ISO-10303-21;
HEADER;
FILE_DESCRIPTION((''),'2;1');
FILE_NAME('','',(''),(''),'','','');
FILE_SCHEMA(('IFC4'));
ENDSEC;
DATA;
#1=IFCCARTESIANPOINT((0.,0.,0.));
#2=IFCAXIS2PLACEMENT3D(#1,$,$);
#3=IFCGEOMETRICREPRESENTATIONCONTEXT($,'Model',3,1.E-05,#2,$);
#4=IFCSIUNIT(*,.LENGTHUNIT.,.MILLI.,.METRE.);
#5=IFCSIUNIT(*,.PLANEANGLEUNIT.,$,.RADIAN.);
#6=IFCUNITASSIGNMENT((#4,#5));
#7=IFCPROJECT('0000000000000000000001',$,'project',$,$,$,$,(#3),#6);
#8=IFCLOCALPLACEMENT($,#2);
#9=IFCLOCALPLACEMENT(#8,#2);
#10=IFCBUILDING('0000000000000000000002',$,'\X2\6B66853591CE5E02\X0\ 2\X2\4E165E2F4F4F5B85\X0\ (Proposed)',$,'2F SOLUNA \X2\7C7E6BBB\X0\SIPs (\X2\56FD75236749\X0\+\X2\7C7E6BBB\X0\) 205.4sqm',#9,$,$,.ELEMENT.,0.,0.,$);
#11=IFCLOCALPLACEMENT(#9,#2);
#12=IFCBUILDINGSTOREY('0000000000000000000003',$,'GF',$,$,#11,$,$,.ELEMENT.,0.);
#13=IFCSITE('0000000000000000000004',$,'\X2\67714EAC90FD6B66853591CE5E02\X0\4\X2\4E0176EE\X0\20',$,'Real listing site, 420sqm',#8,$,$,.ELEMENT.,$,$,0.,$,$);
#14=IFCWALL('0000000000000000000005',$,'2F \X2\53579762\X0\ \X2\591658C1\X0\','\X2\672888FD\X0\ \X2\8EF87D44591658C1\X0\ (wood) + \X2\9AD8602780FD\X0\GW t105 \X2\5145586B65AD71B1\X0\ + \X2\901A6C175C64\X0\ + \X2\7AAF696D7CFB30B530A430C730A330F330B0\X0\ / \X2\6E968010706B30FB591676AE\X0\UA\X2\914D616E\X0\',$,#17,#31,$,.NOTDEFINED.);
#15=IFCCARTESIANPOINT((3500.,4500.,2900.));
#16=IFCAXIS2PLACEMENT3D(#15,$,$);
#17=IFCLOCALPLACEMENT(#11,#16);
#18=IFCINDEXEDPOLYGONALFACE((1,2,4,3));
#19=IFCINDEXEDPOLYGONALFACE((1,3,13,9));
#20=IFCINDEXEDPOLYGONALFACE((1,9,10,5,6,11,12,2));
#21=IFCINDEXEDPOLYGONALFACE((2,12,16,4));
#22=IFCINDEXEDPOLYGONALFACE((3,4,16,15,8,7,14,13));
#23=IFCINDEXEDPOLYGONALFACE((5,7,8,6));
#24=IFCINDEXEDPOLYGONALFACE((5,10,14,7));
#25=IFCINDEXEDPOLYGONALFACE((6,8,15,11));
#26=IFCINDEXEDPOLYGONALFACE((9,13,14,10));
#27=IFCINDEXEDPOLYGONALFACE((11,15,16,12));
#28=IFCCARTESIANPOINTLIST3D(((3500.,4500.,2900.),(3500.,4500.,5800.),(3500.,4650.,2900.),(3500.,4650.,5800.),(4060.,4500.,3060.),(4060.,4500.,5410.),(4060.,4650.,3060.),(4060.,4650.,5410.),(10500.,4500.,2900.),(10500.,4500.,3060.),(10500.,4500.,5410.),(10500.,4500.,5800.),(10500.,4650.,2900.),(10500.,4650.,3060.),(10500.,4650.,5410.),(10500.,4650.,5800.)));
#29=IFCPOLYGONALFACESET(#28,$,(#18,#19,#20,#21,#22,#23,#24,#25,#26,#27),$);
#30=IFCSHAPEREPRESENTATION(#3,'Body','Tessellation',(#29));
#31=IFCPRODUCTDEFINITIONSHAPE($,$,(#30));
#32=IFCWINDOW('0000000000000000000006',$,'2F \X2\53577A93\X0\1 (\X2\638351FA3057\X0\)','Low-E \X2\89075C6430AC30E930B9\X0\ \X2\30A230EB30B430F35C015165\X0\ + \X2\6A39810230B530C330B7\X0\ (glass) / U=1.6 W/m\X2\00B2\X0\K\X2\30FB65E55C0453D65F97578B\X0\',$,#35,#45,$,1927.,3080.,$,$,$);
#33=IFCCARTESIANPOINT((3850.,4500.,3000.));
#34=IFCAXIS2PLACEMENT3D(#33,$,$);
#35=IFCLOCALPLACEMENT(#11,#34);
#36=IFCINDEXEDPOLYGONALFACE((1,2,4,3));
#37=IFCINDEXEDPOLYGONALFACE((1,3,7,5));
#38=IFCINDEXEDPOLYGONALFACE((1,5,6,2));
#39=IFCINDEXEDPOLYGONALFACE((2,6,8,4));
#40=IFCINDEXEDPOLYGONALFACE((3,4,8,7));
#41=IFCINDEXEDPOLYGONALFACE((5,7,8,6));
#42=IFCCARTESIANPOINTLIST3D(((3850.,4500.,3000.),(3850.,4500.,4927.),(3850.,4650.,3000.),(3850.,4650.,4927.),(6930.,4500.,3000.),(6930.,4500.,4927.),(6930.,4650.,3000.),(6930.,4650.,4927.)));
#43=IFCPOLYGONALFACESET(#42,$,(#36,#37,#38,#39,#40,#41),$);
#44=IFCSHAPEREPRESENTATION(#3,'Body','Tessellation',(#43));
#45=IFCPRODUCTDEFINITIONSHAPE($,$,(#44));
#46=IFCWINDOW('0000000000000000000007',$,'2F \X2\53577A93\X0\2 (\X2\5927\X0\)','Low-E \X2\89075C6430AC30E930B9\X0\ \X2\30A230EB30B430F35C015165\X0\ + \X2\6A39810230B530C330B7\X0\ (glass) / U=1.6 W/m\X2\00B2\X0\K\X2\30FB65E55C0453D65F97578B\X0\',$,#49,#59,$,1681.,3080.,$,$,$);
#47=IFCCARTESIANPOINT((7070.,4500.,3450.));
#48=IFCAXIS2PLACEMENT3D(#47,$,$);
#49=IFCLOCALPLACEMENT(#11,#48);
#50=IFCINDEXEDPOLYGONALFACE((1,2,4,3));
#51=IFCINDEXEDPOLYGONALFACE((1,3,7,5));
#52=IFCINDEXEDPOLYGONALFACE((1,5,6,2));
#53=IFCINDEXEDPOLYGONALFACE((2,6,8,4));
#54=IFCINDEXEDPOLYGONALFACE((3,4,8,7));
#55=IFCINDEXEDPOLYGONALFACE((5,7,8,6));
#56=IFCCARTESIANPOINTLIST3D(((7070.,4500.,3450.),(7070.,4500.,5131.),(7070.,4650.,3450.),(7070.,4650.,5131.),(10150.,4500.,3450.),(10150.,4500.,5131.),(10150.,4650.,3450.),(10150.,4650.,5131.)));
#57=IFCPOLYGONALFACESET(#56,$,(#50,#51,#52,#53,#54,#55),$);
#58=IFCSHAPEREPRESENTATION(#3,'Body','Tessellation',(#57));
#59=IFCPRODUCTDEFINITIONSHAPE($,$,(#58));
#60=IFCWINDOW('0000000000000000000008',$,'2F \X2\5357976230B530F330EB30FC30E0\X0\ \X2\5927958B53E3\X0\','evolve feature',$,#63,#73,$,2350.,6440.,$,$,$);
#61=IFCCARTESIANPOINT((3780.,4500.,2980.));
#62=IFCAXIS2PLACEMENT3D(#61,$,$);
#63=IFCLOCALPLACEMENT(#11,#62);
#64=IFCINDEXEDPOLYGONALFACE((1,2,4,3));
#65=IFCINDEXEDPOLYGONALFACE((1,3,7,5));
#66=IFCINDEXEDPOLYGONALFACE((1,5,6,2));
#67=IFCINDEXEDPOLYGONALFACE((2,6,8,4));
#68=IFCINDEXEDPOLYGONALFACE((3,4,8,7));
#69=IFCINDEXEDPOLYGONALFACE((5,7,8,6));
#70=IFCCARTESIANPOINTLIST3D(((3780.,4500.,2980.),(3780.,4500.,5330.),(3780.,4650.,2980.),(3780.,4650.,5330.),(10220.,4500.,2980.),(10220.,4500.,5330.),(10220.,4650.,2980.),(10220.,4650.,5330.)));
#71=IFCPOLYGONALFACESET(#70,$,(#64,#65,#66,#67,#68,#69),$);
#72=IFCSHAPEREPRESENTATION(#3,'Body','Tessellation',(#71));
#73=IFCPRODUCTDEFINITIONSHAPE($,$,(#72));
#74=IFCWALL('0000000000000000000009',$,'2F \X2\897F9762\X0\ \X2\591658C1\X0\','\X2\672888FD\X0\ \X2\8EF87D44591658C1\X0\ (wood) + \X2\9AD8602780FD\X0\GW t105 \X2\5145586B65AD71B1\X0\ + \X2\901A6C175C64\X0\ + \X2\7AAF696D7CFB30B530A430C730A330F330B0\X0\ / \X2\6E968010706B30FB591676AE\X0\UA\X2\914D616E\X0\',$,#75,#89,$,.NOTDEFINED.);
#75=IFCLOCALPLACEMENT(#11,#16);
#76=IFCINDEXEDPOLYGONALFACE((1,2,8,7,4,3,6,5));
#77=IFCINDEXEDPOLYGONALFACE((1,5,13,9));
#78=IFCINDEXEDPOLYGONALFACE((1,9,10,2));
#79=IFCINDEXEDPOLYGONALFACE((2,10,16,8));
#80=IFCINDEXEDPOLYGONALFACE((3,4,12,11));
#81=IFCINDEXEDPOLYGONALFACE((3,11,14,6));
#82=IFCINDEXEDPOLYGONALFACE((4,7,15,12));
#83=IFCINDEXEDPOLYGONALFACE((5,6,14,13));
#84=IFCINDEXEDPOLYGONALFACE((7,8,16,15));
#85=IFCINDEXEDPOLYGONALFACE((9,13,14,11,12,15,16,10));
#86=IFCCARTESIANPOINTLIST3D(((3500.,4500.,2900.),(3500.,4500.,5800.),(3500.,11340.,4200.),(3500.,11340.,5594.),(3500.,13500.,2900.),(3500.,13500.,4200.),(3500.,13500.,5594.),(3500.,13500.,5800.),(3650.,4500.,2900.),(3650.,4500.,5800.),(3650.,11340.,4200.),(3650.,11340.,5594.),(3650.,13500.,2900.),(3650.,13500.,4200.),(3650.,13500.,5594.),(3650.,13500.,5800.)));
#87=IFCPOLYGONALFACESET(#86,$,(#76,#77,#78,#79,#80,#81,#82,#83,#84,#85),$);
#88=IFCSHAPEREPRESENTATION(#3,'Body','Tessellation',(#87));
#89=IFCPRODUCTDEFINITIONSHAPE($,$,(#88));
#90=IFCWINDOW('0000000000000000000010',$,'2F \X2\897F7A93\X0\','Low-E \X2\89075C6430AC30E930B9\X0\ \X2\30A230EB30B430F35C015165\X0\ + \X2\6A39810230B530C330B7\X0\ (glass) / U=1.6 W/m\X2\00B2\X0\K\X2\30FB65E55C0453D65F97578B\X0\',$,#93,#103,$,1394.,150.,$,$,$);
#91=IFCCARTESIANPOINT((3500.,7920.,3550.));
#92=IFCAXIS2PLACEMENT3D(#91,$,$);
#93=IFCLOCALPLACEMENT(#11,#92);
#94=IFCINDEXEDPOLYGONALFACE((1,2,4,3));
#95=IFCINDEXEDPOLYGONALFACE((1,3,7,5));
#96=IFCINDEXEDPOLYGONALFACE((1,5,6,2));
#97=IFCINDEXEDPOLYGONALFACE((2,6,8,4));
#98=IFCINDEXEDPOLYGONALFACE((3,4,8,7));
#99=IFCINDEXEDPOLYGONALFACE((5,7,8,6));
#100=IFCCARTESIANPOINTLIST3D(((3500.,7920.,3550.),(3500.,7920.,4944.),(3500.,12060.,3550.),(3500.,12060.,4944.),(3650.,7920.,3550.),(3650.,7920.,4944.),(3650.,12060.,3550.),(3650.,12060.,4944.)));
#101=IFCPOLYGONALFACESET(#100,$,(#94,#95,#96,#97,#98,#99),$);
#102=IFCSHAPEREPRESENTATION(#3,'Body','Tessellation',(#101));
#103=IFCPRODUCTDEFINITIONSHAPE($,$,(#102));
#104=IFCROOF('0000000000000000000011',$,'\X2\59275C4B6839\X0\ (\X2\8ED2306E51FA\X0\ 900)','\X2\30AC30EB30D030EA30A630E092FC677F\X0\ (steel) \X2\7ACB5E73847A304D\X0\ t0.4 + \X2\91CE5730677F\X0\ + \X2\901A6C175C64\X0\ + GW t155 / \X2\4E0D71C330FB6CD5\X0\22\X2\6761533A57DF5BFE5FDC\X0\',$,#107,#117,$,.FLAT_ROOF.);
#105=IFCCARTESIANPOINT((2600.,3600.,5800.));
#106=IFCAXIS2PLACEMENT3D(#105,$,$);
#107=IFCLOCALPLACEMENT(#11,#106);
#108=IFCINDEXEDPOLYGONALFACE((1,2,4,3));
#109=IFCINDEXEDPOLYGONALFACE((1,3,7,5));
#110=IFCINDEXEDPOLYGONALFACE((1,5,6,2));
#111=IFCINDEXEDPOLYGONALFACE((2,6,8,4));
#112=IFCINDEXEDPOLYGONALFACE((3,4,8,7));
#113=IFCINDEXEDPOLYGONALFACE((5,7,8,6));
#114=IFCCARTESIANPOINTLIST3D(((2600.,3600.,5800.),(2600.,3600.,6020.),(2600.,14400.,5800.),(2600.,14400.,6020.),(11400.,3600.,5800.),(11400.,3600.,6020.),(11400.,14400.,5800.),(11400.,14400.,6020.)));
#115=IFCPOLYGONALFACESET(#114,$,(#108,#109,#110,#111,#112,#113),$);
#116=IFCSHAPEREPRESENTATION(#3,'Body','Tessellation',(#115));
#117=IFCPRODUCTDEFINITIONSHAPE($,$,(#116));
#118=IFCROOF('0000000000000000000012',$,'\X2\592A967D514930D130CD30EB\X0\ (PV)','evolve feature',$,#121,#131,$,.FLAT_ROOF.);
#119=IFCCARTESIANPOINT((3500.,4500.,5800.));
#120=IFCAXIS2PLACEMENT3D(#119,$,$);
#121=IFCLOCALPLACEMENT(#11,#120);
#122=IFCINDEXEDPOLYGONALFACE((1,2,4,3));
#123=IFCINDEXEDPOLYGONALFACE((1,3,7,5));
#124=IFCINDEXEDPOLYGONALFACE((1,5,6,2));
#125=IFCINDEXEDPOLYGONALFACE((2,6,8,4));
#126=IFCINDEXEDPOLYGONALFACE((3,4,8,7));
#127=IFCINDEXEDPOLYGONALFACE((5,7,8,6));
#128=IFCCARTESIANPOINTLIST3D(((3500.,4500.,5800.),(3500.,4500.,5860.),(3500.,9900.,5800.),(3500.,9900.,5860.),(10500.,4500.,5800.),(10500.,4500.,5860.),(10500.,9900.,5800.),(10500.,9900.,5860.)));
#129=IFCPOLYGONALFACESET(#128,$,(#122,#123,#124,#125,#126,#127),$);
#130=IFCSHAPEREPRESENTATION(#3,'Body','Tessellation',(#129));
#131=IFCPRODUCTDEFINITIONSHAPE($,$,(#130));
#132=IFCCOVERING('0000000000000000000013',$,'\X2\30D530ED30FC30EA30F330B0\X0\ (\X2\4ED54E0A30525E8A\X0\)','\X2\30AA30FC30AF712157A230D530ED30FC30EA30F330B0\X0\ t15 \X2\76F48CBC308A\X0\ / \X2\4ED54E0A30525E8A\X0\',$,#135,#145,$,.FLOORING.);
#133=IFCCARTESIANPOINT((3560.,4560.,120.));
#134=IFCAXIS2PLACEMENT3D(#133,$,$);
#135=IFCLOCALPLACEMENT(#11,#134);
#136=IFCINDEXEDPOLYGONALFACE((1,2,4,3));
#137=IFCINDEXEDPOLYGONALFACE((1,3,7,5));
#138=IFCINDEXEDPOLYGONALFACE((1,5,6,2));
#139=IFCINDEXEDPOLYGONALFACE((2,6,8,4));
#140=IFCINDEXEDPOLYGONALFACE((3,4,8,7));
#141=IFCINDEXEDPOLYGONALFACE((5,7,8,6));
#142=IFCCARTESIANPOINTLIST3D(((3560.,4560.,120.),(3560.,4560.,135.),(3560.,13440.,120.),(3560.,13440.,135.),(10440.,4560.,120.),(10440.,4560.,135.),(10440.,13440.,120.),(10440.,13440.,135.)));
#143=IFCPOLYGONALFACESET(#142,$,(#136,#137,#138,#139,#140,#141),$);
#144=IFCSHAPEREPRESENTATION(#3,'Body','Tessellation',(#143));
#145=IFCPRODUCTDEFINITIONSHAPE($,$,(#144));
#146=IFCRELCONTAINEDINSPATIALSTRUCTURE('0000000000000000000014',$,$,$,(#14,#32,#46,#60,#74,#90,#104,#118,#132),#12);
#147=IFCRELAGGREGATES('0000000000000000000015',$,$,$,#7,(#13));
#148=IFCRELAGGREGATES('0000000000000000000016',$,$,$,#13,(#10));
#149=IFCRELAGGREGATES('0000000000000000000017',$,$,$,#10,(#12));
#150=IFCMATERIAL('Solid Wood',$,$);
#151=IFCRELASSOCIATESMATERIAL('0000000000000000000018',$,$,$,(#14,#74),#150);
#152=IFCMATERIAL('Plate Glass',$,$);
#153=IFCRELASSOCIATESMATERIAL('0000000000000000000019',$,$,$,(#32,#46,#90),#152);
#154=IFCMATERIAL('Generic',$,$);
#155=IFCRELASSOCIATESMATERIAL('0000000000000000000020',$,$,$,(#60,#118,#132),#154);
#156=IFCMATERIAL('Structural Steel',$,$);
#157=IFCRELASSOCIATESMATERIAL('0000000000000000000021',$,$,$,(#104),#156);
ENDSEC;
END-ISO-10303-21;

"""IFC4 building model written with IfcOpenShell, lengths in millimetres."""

from ifc_helpers import new_model, si_unit, frame, frame_2d, origin, place, context, project, spatial, rectangle, extrude, material, element, fill, save


model = new_model("IFC4")

# Units and contexts
model_context = context("Model", 3, precision=1e-05, world=origin())
ifc_project = project(units=[si_unit("LENGTHUNIT", "METRE", prefix="MILLI"), si_unit("PLANEANGLEUNIT", "RADIAN")], contexts=[model_context])

# Site, building, storey
site_placement = place(None, origin())
site = spatial("IfcSite", under=ifc_project, at=site_placement, Name="東京都武蔵野市4丁目20", ObjectType="Real listing site, 420sqm", CompositionType="ELEMENT", RefElevation=0.0)
building_placement = place(site_placement, origin())
building = spatial("IfcBuilding", under=site, at=building_placement, Name="武蔵野市 2世帯住宅 (Proposed)", ObjectType="2F SOLUNA 籾殻SIPs (国産杉+籾殻) 205.4sqm", CompositionType="ELEMENT", ElevationOfRefHeight=0.0, ElevationOfTerrain=0.0)
storey_placement = place(building_placement, origin())
storey = spatial("IfcBuildingStorey", under=building, at=storey_placement, Name="GF", CompositionType="ELEMENT", Elevation=0.0)

# Shared definitions
ifc_material_1 = material(Name="Solid Wood")

# Shared definitions
ifc_material_2 = material(Name="Plate Glass")
ifc_material_3 = material(Name="Generic")

# Wall, openings, windows
wall_1_placement = place(storey_placement, frame((3500.0, 4500.0, 2900.0)))
wall_1 = element("IfcWall", 1, at=wall_1_placement, inside=storey, material=ifc_material_1, Name="2F 南面 外壁", Description="木製 軸組外壁 (wood) + 高性能GW t105 充填断熱 + 通気層 + 窯業系サイディング / 準耐火・外皮UA配慮", PredefinedType="NOTDEFINED", context=model_context, shape_type="SweptSolid", body=[
    extrude(rectangle(XDim=7000.0, YDim=150.0, at=frame_2d((3500.0, 75.0))), frame((3500.0, 4500.0, 2900.0)), (0.0, 0.0, 1.0), 2900.0),
])
opening_1_placement = place(storey_placement, frame((3850.0, 4500.0, 3000.0)))
opening_1 = element("IfcOpeningElement", 2, at=opening_1_placement, cuts=wall_1, PredefinedType="NOTDEFINED", context=model_context, shape_type="SweptSolid", body=[
    extrude(rectangle(XDim=3080.0, YDim=150.0, at=frame_2d((1540.0, 75.0))), frame((3850.0, 4500.0, 3000.0)), (0.0, 0.0, 1.0), 1927.0),
])
opening_2_placement = place(storey_placement, frame((7070.0, 4500.0, 3450.0)))
opening_2 = element("IfcOpeningElement", 3, at=opening_2_placement, cuts=wall_1, PredefinedType="NOTDEFINED", context=model_context, shape_type="SweptSolid", body=[
    extrude(rectangle(XDim=3080.0, YDim=150.0, at=frame_2d((1540.0, 75.0))), frame((7070.0, 4500.0, 3450.0)), (0.0, 0.0, 1.0), 1681.0),
])
opening_3_placement = place(storey_placement, frame((3780.0, 4500.0, 2980.0)))
opening_3 = element("IfcOpeningElement", 4, at=opening_3_placement, cuts=wall_1, PredefinedType="NOTDEFINED", context=model_context, shape_type="SweptSolid", body=[
    extrude(rectangle(XDim=6440.0, YDim=150.0, at=frame_2d((3220.0, 75.0))), frame((3780.0, 4500.0, 2980.0)), (0.0, 0.0, 1.0), 2350.0),
])
window_1_placement = place(storey_placement, frame((3850.0, 4500.0, 3000.0)))
window_1 = element("IfcWindow", 5, at=window_1_placement, inside=storey, material=ifc_material_2, Name="2F 南窓1 (掃出し)", Description="Low-E 複層ガラス アルゴン封入 + 樹脂サッシ (glass) / U=1.6 W/m²K・日射取得型", OverallHeight=1927.0, OverallWidth=3080.0, context=model_context, shape_type="SweptSolid", body=[
    extrude(rectangle(XDim=3080.0, YDim=150.0, at=frame_2d((1540.0, 75.0))), frame((3850.0, 4500.0, 3000.0)), (0.0, 0.0, 1.0), 1927.0),
])
fill(opening_1, window_1)
window_2_placement = place(storey_placement, frame((7070.0, 4500.0, 3450.0)))
window_2 = element("IfcWindow", 6, at=window_2_placement, inside=storey, material=ifc_material_2, Name="2F 南窓2 (大)", Description="Low-E 複層ガラス アルゴン封入 + 樹脂サッシ (glass) / U=1.6 W/m²K・日射取得型", OverallHeight=1681.0, OverallWidth=3080.0, context=model_context, shape_type="SweptSolid", body=[
    extrude(rectangle(XDim=3080.0, YDim=150.0, at=frame_2d((1540.0, 75.0))), frame((7070.0, 4500.0, 3450.0)), (0.0, 0.0, 1.0), 1681.0),
])
fill(opening_2, window_2)
window_3_placement = place(storey_placement, frame((3780.0, 4500.0, 2980.0)))
window_3 = element("IfcWindow", 7, at=window_3_placement, inside=storey, material=ifc_material_3, Name="2F 南面サンルーム 大開口", Description="evolve feature", OverallHeight=2350.0, OverallWidth=6440.0, context=model_context, shape_type="SweptSolid", body=[
    extrude(rectangle(XDim=6440.0, YDim=150.0, at=frame_2d((3220.0, 75.0))), frame((3780.0, 4500.0, 2980.0)), (0.0, 0.0, 1.0), 2350.0),
])
fill(opening_3, window_3)

# Wall, opening, window
wall_2_placement = place(storey_placement, frame((3500.0, 4500.0, 2900.0)))
wall_2 = element("IfcWall", 8, at=wall_2_placement, inside=storey, material=ifc_material_1, Name="2F 西面 外壁", Description="木製 軸組外壁 (wood) + 高性能GW t105 充填断熱 + 通気層 + 窯業系サイディング / 準耐火・外皮UA配慮", PredefinedType="NOTDEFINED", context=model_context, shape_type="SweptSolid", body=[
    extrude(rectangle(XDim=150.0, YDim=9000.0, at=frame_2d((75.0, 4500.0))), frame((3500.0, 4500.0, 2900.0)), (0.0, 0.0, 1.0), 2900.0),
])
opening_4_placement = place(storey_placement, frame((3500.0, 7920.0, 3550.0)))
opening_4 = element("IfcOpeningElement", 9, at=opening_4_placement, cuts=wall_2, PredefinedType="NOTDEFINED", context=model_context, shape_type="SweptSolid", body=[
    extrude(rectangle(XDim=150.0, YDim=4140.0, at=frame_2d((75.0, 2070.0))), frame((3500.0, 7920.0, 3550.0)), (0.0, 0.0, 1.0), 1394.0),
])
window_4_placement = place(storey_placement, frame((3500.0, 7920.0, 3550.0)))
window_4 = element("IfcWindow", 10, at=window_4_placement, inside=storey, material=ifc_material_2, Name="2F 西窓", Description="Low-E 複層ガラス アルゴン封入 + 樹脂サッシ (glass) / U=1.6 W/m²K・日射取得型", OverallHeight=1394.0, OverallWidth=150.0, context=model_context, shape_type="SweptSolid", body=[
    extrude(rectangle(XDim=150.0, YDim=4140.0, at=frame_2d((75.0, 2070.0))), frame((3500.0, 7920.0, 3550.0)), (0.0, 0.0, 1.0), 1394.0),
])
fill(opening_4, window_4)

# Roofs
ifc_material_4 = material(Name="Structural Steel")
roof_1_placement = place(storey_placement, frame((2600.0, 3600.0, 5800.0)))
element("IfcRoof", 11, at=roof_1_placement, inside=storey, material=ifc_material_4, Name="大屋根 (軒の出 900)", Description="ガルバリウム鋼板 (steel) 立平葺き t0.4 + 野地板 + 通気層 + GW t155 / 不燃・法22条区域対応", PredefinedType="FLAT_ROOF", context=model_context, shape_type="SweptSolid", body=[
    extrude(rectangle(XDim=8800.0, YDim=10800.0, at=frame_2d((4400.0, 5400.0))), frame((2600.0, 3600.0, 5800.0)), (0.0, 0.0, 1.0), 220.0),
])
roof_2_placement = place(storey_placement, frame((3500.0, 4500.0, 5800.0)))
element("IfcRoof", 12, at=roof_2_placement, inside=storey, material=ifc_material_3, Name="太陽光パネル (PV)", Description="evolve feature", PredefinedType="FLAT_ROOF", context=model_context, shape_type="SweptSolid", body=[
    extrude(rectangle(XDim=7000.0, YDim=5400.0, at=frame_2d((3500.0, 2700.0))), frame((3500.0, 4500.0, 5800.0)), (0.0, 0.0, 1.0), 60.0),
])

# Covering
covering_placement = place(storey_placement, frame((3560.0, 4560.0, 120.0)))
element("IfcCovering", 13, at=covering_placement, inside=storey, material=ifc_material_3, Name="フローリング (仕上げ床)", Description="オーク無垢フローリング t15 直貼り / 仕上げ床", PredefinedType="FLOORING", context=model_context, shape_type="SweptSolid", body=[
    extrude(rectangle(XDim=6880.0, YDim=8880.0, at=frame_2d((3440.0, 4440.0))), frame((3560.0, 4560.0, 120.0)), (0.0, 0.0, 1.0), 15.0),
])

save(model, "model.ifc")
